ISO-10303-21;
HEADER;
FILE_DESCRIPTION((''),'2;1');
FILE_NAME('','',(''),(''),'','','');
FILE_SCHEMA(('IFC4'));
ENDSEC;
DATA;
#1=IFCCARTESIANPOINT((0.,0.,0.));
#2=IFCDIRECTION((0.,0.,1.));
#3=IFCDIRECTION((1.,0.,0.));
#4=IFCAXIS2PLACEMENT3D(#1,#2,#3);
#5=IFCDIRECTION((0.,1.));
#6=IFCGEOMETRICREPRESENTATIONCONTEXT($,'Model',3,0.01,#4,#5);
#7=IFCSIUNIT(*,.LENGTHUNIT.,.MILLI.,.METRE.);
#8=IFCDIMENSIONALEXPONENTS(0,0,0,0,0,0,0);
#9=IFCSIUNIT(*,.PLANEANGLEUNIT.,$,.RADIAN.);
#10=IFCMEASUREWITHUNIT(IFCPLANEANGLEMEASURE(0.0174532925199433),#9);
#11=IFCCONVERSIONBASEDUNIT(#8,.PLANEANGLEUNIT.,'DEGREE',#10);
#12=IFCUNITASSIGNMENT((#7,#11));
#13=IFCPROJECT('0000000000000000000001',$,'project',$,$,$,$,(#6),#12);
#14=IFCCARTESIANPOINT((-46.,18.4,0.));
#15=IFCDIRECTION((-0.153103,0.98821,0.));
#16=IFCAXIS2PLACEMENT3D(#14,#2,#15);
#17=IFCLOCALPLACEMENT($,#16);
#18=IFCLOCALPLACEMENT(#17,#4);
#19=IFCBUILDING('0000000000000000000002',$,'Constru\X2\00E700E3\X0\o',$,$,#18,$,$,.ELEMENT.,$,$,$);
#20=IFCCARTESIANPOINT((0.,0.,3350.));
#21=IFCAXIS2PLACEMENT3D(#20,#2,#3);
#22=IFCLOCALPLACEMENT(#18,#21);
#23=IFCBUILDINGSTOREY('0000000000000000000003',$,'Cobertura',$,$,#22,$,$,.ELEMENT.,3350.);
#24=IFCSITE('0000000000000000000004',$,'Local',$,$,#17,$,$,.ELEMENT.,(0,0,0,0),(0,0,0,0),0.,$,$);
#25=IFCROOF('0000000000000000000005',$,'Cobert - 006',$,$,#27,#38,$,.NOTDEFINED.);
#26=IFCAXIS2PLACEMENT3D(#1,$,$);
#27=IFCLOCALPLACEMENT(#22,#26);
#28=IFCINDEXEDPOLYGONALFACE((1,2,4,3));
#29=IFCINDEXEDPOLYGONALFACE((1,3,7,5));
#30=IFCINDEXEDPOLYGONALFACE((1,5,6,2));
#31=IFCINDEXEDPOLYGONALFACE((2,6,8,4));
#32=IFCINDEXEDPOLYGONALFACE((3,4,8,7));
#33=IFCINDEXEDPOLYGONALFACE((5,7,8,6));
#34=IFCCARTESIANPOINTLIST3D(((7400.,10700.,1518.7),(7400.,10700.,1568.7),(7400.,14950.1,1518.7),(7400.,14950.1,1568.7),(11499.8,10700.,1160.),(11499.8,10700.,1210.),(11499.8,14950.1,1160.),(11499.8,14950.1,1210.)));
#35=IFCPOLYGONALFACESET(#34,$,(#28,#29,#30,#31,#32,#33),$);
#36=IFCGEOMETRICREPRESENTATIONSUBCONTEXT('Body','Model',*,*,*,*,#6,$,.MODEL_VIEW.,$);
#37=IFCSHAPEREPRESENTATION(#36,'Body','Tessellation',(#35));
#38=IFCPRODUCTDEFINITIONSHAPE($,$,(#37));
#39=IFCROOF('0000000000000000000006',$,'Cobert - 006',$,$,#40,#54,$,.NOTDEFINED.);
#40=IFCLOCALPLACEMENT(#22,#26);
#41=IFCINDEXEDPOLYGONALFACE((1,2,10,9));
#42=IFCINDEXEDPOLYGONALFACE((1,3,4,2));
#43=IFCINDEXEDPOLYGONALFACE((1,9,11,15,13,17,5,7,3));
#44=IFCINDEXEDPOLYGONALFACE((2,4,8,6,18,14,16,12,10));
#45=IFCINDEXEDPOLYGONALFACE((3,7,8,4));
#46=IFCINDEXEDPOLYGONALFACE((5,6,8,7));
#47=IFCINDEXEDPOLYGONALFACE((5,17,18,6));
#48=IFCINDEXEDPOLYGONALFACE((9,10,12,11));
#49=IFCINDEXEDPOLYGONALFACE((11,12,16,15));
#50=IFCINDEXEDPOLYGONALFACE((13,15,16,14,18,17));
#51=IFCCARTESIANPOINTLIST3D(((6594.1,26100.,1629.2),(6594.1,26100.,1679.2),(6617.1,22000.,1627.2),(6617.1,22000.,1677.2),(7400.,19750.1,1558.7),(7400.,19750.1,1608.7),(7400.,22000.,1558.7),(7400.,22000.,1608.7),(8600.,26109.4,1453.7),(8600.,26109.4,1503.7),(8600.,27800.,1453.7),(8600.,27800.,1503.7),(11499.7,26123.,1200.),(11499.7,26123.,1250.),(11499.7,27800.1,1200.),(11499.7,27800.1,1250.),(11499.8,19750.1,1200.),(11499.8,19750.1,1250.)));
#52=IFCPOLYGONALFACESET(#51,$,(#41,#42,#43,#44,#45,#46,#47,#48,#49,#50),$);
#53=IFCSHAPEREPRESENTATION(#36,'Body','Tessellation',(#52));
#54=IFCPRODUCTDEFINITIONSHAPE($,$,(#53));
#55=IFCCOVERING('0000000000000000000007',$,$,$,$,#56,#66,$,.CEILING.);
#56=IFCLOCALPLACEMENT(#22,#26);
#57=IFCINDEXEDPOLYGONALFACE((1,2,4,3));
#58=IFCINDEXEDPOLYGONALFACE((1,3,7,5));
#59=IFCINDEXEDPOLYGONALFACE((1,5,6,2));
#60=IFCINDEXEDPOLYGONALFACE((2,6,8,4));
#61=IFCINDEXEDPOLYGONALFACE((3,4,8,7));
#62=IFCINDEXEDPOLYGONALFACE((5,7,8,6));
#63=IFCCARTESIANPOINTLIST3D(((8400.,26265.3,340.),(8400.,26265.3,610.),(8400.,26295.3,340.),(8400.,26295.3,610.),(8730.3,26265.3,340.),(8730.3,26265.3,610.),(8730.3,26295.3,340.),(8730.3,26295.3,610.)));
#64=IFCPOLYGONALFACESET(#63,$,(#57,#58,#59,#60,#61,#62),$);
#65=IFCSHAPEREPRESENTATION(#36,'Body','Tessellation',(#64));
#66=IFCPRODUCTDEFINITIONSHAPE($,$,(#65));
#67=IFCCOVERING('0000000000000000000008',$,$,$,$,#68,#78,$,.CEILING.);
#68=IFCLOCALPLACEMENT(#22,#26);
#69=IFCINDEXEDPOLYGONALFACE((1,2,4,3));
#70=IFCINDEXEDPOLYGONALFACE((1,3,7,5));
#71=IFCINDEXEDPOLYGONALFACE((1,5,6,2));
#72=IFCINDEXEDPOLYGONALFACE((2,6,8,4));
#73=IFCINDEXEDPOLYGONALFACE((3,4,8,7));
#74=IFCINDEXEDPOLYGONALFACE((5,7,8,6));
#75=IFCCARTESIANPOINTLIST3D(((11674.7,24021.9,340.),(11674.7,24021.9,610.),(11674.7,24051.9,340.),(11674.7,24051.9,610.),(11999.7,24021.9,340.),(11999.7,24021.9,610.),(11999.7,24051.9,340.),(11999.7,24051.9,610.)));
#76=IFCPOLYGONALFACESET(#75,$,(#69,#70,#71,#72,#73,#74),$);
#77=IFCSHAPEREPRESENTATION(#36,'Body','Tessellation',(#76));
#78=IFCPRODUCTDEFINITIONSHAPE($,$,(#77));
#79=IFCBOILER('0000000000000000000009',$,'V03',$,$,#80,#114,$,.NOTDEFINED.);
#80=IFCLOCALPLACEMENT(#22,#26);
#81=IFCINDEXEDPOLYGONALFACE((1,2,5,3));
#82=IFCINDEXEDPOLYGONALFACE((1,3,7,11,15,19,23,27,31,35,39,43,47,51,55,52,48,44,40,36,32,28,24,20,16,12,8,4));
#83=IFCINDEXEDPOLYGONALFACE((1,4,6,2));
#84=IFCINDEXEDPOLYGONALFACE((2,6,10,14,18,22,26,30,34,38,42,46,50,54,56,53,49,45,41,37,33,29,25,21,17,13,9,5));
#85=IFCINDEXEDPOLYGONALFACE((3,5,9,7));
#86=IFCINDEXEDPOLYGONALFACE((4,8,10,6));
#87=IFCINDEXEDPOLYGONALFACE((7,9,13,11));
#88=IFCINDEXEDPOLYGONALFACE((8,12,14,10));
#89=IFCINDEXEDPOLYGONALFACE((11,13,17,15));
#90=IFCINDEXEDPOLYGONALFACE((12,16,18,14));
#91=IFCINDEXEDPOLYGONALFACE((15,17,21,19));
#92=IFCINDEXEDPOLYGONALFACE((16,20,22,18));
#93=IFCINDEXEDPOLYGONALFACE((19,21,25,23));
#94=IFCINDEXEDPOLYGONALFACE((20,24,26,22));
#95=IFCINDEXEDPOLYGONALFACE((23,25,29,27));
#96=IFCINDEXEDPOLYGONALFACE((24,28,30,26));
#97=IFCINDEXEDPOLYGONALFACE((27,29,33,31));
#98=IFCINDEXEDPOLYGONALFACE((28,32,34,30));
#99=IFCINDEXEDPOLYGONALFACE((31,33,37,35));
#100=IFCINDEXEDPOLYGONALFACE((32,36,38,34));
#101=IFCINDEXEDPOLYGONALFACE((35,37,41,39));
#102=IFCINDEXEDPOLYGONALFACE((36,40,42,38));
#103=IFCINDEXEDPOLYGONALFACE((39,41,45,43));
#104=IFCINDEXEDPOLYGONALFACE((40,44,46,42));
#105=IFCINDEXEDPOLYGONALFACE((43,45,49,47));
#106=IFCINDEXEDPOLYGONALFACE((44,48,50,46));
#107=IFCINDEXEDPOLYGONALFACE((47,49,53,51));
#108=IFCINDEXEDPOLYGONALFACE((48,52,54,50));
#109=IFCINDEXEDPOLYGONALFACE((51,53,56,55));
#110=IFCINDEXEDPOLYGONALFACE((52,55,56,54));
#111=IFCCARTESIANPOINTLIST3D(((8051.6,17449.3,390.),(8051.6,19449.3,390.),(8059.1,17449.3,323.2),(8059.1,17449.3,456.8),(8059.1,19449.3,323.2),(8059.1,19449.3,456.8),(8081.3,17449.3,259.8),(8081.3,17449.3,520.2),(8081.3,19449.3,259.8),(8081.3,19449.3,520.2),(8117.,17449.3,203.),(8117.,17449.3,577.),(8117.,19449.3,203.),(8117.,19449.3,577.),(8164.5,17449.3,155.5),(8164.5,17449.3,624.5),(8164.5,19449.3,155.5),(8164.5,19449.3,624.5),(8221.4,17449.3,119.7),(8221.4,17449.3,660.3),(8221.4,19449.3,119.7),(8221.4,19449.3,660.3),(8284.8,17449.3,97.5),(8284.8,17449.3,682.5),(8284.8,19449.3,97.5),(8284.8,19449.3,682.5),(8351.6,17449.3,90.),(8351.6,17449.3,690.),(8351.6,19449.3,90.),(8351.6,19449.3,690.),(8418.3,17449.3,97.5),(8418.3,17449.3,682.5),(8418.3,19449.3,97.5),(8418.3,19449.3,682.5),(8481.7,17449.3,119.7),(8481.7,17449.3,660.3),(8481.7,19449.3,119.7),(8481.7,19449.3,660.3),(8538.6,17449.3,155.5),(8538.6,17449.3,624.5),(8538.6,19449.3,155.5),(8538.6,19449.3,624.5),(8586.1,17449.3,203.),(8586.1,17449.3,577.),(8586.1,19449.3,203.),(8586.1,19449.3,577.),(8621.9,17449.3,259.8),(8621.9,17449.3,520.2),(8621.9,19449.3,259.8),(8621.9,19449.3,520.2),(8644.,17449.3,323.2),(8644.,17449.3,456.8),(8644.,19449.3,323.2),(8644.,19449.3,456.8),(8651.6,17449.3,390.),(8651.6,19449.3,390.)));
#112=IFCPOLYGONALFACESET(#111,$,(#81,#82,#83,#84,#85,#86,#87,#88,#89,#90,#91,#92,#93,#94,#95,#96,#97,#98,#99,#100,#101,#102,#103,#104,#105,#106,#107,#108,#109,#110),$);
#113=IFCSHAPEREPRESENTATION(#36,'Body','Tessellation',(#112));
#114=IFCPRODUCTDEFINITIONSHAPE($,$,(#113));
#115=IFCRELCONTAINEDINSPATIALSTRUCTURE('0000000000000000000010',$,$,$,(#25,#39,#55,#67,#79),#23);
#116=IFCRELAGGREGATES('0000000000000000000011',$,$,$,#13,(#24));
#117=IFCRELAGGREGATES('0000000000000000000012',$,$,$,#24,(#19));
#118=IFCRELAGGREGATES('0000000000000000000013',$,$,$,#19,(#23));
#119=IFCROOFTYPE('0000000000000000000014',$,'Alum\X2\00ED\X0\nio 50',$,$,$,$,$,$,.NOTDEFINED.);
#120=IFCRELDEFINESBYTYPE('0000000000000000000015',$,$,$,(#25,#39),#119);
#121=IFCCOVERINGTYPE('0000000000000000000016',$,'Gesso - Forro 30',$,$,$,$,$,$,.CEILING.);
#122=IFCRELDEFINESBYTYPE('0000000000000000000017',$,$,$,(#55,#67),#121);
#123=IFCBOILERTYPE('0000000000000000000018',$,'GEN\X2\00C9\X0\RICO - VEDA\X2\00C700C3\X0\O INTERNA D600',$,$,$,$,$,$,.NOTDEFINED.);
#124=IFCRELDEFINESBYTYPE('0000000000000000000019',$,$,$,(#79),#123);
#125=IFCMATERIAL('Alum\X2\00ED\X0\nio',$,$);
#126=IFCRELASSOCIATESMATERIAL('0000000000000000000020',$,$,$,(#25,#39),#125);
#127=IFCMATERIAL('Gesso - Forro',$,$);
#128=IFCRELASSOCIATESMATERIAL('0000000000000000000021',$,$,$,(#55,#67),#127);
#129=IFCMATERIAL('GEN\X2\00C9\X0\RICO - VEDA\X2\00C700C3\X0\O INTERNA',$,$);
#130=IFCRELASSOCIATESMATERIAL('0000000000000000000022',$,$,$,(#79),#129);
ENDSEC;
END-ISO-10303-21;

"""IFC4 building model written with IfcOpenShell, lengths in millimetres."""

from ifc_helpers import new_model, entity, si_unit, converted_unit, direction, frame, frame_2d, origin_with_axes, place, context, subcontext, project, spatial, line, indexed_curve, circle, outline, extrude, material, type_object, element, save


model = new_model("IFC4")

# Units and contexts
model_context = context("Model", 3, precision=0.01, world=origin_with_axes(), true_north=direction((0.0, 1.0)))
body_context = subcontext(model_context, "Body", "Model", "MODEL_VIEW")
ifc_project = project(units=[si_unit("LENGTHUNIT", "METRE", prefix="MILLI"), converted_unit("PLANEANGLEUNIT", "DEGREE", entity("IfcPlaneAngleMeasure", 0.0174532925199433), si_unit("PLANEANGLEUNIT", "RADIAN"), dimensions=[0, 0, 0, 0, 0, 0, 0])], contexts=[model_context])

# Site, building, storey
site_placement = place(None, frame((-46.0, 18.4, 0.0), z_axis=(0.0, 0.0, 1.0), x_axis=(-0.153103, 0.98821, 0.0)))
site = spatial("IfcSite", under=ifc_project, at=site_placement, Name="Local", CompositionType="ELEMENT", RefLatitude=(0, 0, 0, 0), RefLongitude=(0, 0, 0, 0), RefElevation=0.0)
building_placement = place(site_placement, origin_with_axes())
building = spatial("IfcBuilding", under=site, at=building_placement, Name="Construção", CompositionType="ELEMENT")
storey_placement = place(building_placement, frame((0.0, 0.0, 3350.0), z_axis=(0.0, 0.0, 1.0), x_axis=(1.0, 0.0, 0.0)))
storey = spatial("IfcBuildingStorey", under=building, at=storey_placement, Name="Cobertura", CompositionType="ELEMENT", Elevation=3350.0)

# Roofs
ifc_material_1 = material(Name="Alumínio")
roof_type = type_object("IfcRoofType", Name="Alumínio 50", PredefinedType="NOTDEFINED")
roof_1_placement = place(storey_placement, frame((11499.8, 14950.1, 1160.0), z_axis=(0.0, 0.0, 1.0), x_axis=(0.0, -1.0, 0.0)))
element("IfcRoof", 1, at=roof_1_placement, inside=storey, type_object=roof_type, material=ifc_material_1, Name="Cobert - 006", PredefinedType="NOTDEFINED", context=body_context, shape_type="SweptSolid", body=[
    extrude(outline(indexed_curve([(4250.1, -4115.5), (4250.1, 0.0), (0.0, 0.0), (0.0, -4115.5)], segments=[line(1, 2, 3, 4, 1)])), frame((0.0, 0.0, 0.0), z_axis=(0.0, 0.087156, 0.996195), x_axis=(1.0, 0.0, 0.0)), (0.0, -0.087156, 0.996195), 50.0),
])
roof_2_placement = place(storey_placement, frame((11499.7, 27800.1, 1200.0), z_axis=(0.0, 0.0, 1.0), x_axis=(0.000019, -1.0, 0.0)))
element("IfcRoof", 2, at=roof_2_placement, inside=storey, type_object=roof_type, material=ifc_material_1, Name="Cobert - 006", PredefinedType="NOTDEFINED", context=body_context, shape_type="SweptSolid", body=[
    extrude(outline(indexed_curve([(1700.0, -4924.4), (5800.0, -4901.3), (5800.0, -4115.5), (8049.9, -4115.5), (8050.0, 0.0), (1677.1, 0.0), (0.0, 0.0), (0.0, -2910.8), (1690.6, -2910.8)], segments=[line(1, 2, 3, 4, 5, 6, 7, 8, 9, 1)])), frame((0.0, 0.0, 0.0), z_axis=(0.0, 0.087156, 0.996195), x_axis=(1.0, 0.0, 0.0)), (0.0, -0.087156, 0.996195), 50.0),
])

# Coverings
ifc_material_2 = material(Name="Gesso - Forro")
covering_type = type_object("IfcCoveringType", Name="Gesso - Forro 30", PredefinedType="CEILING")
covering_1_placement = place(storey_placement, frame((8730.3, 26295.3, 340.0), z_axis=(0.0, 0.0, 1.0), x_axis=(-1.0, -0.000015, 0.0)))
element("IfcCovering", 3, at=covering_1_placement, inside=storey, type_object=covering_type, material=ifc_material_2, PredefinedType="CEILING", context=body_context, shape_type="SweptSolid", body=[
    extrude(outline(indexed_curve([(0.0, 0.0), (330.4, 0.0), (330.4, 30.0), (0.0, 30.0)], segments=[line(1, 2, 3, 4, 1)])), origin_with_axes(), (0.0, 0.0, 1.0), 270.0),
])
covering_2_placement = place(storey_placement, frame((11674.7, 24051.9, 340.0), z_axis=(0.0, 0.0, 1.0), x_axis=(1.0, 0.0, 0.0)))
element("IfcCovering", 4, at=covering_2_placement, inside=storey, type_object=covering_type, material=ifc_material_2, PredefinedType="CEILING", context=body_context, shape_type="SweptSolid", body=[
    extrude(outline(indexed_curve([(0.0, -30.0), (325.0, -30.0), (325.0, 0.0), (0.0, 0.0)], segments=[line(1, 2, 3, 4, 1)])), origin_with_axes(), (0.0, 0.0, 1.0), 270.0),
])

# Boiler
ifc_material_3 = material(Name="GENÉRICO - VEDAÇÃO INTERNA")
boiler_type = type_object("IfcBoilerType", Name="GENÉRICO - VEDAÇÃO INTERNA D600", PredefinedType="NOTDEFINED")
boiler_placement = place(storey_placement, frame((8651.6, 19449.3, 690.0), z_axis=(0.0, 0.0, 1.0), x_axis=(-1.0, 0.0, 0.0)))
element("IfcBoiler", 5, at=boiler_placement, inside=storey, type_object=boiler_type, material=ifc_material_3, Name="V03", PredefinedType="NOTDEFINED", context=body_context, shape_type="SweptSolid", body=[
    extrude(circle(Radius=300.0, at=frame_2d((-300.0, 300.0), x_axis=(1.0, 0.0))), frame((0.0, 0.0, 0.0), z_axis=(0.0, 1.0, 0.0), x_axis=(0.0, 0.0, 1.0)), (0.0, 0.0, 1.0), 2000.0),
])

save(model, "model.ifc")
